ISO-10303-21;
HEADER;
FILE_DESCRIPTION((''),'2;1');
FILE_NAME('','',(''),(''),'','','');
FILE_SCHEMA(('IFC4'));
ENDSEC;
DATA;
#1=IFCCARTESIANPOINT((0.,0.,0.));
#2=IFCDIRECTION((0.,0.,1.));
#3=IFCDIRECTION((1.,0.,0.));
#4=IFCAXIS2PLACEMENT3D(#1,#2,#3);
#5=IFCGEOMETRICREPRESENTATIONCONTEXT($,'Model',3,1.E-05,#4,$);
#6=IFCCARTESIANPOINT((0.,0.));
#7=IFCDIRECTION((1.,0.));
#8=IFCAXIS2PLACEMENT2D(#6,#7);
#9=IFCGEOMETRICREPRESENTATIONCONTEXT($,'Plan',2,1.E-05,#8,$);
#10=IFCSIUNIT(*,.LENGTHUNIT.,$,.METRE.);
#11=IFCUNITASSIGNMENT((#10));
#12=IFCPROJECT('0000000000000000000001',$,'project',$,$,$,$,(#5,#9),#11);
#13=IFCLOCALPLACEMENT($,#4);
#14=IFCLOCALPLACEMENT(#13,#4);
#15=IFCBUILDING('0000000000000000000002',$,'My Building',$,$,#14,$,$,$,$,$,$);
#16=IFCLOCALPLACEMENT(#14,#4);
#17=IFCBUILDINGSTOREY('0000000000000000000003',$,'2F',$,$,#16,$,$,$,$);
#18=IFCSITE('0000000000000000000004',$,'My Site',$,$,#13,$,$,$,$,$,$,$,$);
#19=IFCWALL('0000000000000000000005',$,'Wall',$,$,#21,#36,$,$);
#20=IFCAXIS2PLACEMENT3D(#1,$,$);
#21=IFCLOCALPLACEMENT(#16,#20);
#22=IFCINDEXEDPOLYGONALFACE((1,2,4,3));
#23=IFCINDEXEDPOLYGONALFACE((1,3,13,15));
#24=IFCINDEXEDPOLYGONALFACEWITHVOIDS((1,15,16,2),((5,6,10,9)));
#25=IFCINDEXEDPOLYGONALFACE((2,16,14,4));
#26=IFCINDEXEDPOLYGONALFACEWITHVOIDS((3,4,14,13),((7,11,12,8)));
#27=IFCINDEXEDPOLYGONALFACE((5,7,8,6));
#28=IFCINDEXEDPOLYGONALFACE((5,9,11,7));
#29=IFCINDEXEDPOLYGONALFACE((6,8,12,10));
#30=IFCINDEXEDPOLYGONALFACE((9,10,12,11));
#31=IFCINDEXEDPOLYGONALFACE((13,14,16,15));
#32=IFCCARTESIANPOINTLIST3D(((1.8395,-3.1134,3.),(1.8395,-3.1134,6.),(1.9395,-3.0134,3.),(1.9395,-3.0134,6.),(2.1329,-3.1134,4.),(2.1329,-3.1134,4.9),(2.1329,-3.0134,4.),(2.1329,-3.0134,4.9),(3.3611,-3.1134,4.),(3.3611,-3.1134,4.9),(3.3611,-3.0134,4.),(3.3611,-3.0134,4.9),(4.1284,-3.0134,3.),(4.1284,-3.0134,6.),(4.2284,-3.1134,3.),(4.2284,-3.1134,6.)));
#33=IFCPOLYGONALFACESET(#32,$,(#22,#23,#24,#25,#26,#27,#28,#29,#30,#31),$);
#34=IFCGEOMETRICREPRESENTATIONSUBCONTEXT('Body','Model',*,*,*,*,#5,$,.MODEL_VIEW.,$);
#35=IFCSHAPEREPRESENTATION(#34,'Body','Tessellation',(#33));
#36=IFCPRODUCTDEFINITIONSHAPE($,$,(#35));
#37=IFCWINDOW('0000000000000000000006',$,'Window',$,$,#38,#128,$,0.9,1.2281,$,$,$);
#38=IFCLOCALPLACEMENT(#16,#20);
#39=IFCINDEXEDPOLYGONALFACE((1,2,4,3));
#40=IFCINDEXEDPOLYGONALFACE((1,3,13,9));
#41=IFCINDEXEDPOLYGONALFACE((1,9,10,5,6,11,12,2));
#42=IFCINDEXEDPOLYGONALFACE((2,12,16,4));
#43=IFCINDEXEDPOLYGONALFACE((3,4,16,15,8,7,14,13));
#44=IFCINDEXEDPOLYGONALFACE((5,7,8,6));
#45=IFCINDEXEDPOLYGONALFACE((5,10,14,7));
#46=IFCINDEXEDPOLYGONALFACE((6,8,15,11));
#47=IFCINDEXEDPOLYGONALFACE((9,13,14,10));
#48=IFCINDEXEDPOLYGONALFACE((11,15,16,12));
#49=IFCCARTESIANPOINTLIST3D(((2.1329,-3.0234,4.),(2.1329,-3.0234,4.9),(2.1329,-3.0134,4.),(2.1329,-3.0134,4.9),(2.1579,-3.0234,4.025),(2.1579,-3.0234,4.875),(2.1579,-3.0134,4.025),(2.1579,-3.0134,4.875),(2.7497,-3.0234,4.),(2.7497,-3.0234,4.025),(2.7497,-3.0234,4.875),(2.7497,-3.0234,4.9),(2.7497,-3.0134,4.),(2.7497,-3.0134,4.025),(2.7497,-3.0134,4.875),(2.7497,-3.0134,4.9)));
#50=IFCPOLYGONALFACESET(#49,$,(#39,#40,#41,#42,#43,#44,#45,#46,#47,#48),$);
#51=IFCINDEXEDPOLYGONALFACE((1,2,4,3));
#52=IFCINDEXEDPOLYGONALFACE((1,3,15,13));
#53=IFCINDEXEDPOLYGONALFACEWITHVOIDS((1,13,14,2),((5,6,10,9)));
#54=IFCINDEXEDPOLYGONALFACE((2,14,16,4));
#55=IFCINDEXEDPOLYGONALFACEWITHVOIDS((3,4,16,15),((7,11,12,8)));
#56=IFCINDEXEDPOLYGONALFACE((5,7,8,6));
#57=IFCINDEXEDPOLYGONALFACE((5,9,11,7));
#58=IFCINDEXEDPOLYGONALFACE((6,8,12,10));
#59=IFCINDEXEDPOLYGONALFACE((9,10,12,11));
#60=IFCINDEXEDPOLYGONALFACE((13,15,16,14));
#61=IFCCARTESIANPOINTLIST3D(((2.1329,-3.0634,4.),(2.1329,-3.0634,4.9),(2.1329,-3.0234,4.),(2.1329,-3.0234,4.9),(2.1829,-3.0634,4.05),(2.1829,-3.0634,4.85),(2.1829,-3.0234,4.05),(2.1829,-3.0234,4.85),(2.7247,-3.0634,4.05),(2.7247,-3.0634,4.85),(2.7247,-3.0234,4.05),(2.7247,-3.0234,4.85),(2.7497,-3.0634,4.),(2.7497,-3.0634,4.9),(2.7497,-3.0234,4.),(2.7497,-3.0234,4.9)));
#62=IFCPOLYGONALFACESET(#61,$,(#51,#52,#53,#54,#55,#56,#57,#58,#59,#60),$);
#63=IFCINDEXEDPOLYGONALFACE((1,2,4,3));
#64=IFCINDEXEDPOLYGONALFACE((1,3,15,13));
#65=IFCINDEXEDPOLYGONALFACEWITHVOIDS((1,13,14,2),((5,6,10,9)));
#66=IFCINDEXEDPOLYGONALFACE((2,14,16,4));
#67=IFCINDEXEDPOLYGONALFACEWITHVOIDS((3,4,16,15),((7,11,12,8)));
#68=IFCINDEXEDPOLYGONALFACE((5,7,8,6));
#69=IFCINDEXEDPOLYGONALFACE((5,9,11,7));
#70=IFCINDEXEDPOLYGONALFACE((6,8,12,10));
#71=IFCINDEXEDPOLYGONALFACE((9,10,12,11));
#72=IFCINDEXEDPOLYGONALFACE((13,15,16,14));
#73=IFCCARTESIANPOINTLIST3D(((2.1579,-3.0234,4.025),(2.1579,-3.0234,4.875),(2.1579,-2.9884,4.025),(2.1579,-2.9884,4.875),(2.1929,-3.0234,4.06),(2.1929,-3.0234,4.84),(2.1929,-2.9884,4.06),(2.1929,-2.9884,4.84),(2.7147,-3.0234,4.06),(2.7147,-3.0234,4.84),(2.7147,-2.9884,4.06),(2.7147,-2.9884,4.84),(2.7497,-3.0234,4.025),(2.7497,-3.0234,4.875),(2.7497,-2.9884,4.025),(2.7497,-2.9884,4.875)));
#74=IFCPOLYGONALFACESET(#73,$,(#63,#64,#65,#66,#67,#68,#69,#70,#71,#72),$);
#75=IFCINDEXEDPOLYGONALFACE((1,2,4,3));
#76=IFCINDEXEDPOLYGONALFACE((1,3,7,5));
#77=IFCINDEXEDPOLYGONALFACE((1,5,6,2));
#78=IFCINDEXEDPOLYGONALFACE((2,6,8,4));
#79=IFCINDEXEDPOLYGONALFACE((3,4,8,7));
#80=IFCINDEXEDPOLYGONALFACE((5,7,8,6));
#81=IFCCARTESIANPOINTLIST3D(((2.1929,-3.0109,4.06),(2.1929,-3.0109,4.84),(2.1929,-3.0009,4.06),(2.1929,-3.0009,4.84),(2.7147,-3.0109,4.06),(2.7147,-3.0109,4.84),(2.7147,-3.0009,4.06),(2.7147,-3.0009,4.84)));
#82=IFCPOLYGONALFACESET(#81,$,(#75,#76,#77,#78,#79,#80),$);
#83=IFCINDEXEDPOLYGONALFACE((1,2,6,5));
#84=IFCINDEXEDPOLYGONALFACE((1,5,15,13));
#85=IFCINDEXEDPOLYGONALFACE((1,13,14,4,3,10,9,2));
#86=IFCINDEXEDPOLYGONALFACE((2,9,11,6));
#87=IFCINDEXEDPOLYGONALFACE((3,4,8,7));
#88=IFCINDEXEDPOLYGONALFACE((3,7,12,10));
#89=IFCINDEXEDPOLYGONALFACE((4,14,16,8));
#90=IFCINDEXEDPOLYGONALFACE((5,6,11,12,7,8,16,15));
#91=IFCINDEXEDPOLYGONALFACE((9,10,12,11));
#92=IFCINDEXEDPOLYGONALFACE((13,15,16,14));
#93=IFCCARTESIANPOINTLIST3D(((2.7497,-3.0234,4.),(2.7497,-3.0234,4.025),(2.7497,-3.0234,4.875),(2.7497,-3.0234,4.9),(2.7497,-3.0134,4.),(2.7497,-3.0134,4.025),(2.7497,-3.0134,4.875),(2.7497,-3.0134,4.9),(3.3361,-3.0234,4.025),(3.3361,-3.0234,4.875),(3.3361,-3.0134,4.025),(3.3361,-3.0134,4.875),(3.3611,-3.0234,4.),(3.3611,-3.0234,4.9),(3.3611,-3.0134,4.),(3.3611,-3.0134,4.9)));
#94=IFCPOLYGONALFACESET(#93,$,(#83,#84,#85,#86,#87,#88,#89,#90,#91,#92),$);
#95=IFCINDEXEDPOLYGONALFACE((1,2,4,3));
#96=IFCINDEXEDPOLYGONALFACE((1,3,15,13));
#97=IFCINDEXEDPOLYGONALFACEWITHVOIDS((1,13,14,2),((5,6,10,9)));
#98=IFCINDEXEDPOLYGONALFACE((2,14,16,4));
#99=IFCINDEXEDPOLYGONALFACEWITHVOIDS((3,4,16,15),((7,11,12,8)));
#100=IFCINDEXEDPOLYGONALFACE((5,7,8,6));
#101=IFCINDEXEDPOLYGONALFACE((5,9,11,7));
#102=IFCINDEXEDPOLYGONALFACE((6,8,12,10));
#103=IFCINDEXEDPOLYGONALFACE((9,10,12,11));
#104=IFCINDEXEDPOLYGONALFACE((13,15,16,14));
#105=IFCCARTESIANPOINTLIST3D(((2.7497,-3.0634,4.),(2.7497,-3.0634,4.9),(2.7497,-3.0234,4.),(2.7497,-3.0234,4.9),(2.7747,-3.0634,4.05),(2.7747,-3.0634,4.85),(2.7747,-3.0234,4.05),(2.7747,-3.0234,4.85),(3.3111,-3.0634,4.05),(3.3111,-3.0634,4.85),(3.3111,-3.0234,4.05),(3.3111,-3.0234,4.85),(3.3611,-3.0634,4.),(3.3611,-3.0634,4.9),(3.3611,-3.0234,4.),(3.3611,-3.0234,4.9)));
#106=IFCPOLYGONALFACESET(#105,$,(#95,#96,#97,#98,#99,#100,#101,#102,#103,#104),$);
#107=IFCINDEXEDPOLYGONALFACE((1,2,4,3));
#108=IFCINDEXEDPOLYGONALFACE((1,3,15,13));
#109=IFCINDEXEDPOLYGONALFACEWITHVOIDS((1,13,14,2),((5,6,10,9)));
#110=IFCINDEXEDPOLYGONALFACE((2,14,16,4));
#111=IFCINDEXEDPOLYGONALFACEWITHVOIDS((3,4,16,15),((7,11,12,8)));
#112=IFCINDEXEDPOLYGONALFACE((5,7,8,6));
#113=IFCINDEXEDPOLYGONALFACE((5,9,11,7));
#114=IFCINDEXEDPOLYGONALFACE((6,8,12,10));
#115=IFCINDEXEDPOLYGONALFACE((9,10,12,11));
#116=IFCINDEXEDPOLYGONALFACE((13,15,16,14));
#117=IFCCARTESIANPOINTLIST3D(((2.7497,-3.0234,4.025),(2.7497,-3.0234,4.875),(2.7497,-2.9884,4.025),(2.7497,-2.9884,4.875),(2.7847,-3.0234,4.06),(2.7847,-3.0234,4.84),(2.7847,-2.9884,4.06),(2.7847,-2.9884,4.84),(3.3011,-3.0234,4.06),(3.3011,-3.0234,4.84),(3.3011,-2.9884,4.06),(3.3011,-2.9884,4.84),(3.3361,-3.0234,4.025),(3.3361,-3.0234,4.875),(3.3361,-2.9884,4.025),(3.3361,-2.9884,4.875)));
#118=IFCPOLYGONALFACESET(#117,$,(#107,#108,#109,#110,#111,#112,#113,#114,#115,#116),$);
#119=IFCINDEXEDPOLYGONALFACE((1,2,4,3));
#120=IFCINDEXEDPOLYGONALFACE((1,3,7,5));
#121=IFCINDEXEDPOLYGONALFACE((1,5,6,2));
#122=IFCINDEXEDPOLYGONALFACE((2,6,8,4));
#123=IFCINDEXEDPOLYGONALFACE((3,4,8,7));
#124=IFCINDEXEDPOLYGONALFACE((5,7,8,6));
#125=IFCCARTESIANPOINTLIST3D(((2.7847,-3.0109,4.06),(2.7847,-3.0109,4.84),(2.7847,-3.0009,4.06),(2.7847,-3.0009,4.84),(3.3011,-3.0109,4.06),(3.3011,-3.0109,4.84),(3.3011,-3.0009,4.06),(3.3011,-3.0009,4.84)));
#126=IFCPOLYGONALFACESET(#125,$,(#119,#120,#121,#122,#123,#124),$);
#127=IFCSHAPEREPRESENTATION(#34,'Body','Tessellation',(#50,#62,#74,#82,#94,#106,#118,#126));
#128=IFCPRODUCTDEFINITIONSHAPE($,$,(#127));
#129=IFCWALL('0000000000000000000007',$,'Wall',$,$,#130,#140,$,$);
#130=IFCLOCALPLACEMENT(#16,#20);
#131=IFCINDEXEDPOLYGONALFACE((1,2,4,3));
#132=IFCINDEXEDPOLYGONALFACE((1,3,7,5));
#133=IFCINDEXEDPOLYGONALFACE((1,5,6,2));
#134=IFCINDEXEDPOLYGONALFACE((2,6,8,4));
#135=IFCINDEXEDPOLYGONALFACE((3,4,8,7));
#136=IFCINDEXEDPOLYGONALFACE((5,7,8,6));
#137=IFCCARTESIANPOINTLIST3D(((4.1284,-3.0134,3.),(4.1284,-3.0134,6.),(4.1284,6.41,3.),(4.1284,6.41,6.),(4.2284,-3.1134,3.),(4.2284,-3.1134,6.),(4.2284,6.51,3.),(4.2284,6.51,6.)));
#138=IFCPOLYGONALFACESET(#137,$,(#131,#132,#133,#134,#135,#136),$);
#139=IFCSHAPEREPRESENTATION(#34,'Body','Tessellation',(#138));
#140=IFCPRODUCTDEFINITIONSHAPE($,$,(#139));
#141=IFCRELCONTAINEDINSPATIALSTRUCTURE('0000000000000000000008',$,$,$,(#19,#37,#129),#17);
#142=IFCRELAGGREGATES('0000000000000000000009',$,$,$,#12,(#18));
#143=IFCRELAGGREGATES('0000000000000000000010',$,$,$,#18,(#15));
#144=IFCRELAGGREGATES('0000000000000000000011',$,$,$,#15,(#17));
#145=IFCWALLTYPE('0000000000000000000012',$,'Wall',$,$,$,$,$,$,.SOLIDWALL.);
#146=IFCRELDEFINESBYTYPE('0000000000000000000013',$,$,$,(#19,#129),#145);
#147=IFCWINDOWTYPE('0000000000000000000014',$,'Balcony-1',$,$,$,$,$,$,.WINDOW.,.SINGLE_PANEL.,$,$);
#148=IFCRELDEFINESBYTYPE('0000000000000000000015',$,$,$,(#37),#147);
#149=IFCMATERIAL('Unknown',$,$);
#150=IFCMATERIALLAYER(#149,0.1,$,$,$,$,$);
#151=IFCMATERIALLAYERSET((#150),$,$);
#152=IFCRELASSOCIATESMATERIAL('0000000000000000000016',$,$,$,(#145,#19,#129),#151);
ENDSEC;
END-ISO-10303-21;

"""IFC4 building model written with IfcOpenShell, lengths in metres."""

from ifc_helpers import new_model, entity, si_unit, frame, origin_with_axes, origin_2d_with_axis, place, context, subcontext, project, spatial, line, indexed_curve, outline, extrude, shape, source, transform, mapped, material, layer, layer_set, layer_usage, type_object, type_shapes, element, fill, save


model = new_model("IFC4")

# Units and contexts
model_context = context("Model", 3, precision=1e-05, world=origin_with_axes())
plan_context = context("Plan", 2, precision=1e-05, world=origin_2d_with_axis())
body_context_1 = subcontext(model_context, "Body", "Model", "MODEL_VIEW")
body_context_2 = subcontext(plan_context, "Body", "Plan", "PLAN_VIEW")
ifc_project = project(units=[si_unit("LENGTHUNIT", "METRE")], contexts=[model_context, plan_context])

# Site, building, storey
site_placement = place(None, origin_with_axes())
site = spatial("IfcSite", under=ifc_project, at=site_placement, Name="My Site")
building_placement = place(site_placement, origin_with_axes())
building = spatial("IfcBuilding", under=site, at=building_placement, Name="My Building")
storey_placement = place(building_placement, origin_with_axes())
storey = spatial("IfcBuildingStorey", under=building, at=storey_placement, Name="2F")

# Shared definitions
ifc_material = material(Name="Unknown")
ifc_layer = layer(ifc_material, 0.1)
ifc_layer_set = layer_set([ifc_layer])
wall_type = type_object("IfcWallType", Name="Wall", PredefinedType="SOLIDWALL", material=ifc_layer_set)

# Wall, opening, window
ifc_layer_usage_1 = layer_usage(ifc_layer_set, "AXIS2", "POSITIVE", 0.0)
wall_1_placement = place(storey_placement, frame((1.8395, -3.1134, 3.0), z_axis=(0.0, 0.0, 1.0), x_axis=(1.0, 0.0, 0.0)))
wall_1 = element("IfcWall", 1, at=wall_1_placement, inside=storey, type_object=wall_type, material=ifc_layer_usage_1, Name="Wall", context=body_context_1, shape_type="SweptSolid", body=[
    extrude(outline(indexed_curve([(0.0, 0.0), (0.1, 0.1), (2.2889, 0.1), (2.3889, 0.0)], segments=[line(1, 2, 3, 4, 1)])), origin_with_axes(), (0.0, 0.0, 1.0), 3.0),
])
shared_shape_1 = source(origin_with_axes(), body_context_1, "Body", "SweptSolid", [
    extrude(outline(indexed_curve([(0.0, 0.0), (1.2281, 0.0), (1.2281, 0.9), (0.0, 0.9)], segments=[line(1, 2, 3, 4, 1)])), frame((0.0, -0.6, 0.0), z_axis=(0.0, -1.0, 0.0), x_axis=(1.0, 0.0, 0.0)), (0.0, 0.0, -1.0), 1.2),
])
opening_1_placement = place(wall_1_placement, frame((0.2934, 0.0, 1.0), z_axis=(0.0, 0.0, 1.0), x_axis=(1.0, 0.0, 0.0)))
opening_1 = element("IfcOpeningElement", 2, at=opening_1_placement, cuts=wall_1, PredefinedType="OPENING", context=body_context_1, shape_type="MappedRepresentation", body=[
    mapped(shared_shape_1, transform((0.0, 0.0, 0.0), x_axis=(1.0, 0.0, 0.0), y_axis=(0.0, 1.0, 0.0), z_axis=(0.0, 0.0, 1.0), scale=1.0)),
])
window_type_1 = type_object("IfcWindowType", Name="Balcony-1", PartitioningType="SINGLE_PANEL", PredefinedType="WINDOW")
shared_shape_2 = source(origin_with_axes(), body_context_1, "Body", "SweptSolid", [
    extrude(outline(indexed_curve([(0.6167, 0.0), (0.0, 0.0), (0.0, 0.9), (0.6167, 0.9), (0.6167, 0.875), (0.025, 0.875), (0.025, 0.025), (0.6167, 0.025)], segments=[line(1, 2, 3, 4, 5, 6, 7, 8, 1)])), frame((0.0, 0.09, 0.0), z_axis=(0.0, -1.0, 0.0), x_axis=(1.0, 0.0, 0.0)), (0.0, 0.0, -1.0), 0.01),
    extrude(outline(indexed_curve([(0.0, 0.0), (0.6167, 0.0), (0.6167, 0.9), (0.0, 0.9)], segments=[line(1, 2, 3, 4, 1)]), holes=[indexed_curve([(0.05, 0.05), (0.5917, 0.05), (0.5917, 0.85), (0.05, 0.85)], segments=[line(1, 2, 3, 4, 1)])]), frame((0.0, 0.05, 0.0), z_axis=(0.0, -1.0, 0.0), x_axis=(1.0, 0.0, 0.0)), (0.0, 0.0, -1.0), 0.04),
    extrude(outline(indexed_curve([(0.0, 0.0), (0.5917, 0.0), (0.5917, 0.85), (0.0, 0.85)], segments=[line(1, 2, 3, 4, 1)]), holes=[indexed_curve([(0.035, 0.035), (0.5567, 0.035), (0.5567, 0.815), (0.035, 0.815)], segments=[line(1, 2, 3, 4, 1)])]), frame((0.025, 0.09, 0.025), z_axis=(0.0, -1.0, 0.0), x_axis=(1.0, 0.0, 0.0)), (0.0, 0.0, -1.0), 0.035),
    extrude(outline(indexed_curve([(0.035, 0.035), (0.5567, 0.035), (0.5567, 0.815), (0.035, 0.815)], segments=[line(1, 2, 3, 4, 1)])), frame((0.025, 0.1025, 0.025), z_axis=(0.0, -1.0, 0.0), x_axis=(1.0, 0.0, 0.0)), (0.0, 0.0, -1.0), 0.01),
    extrude(outline(indexed_curve([(0.0, 0.9), (0.6114, 0.9), (0.6114, 0.0), (0.0, 0.0), (0.0, 0.025), (0.5864, 0.025), (0.5864, 0.875), (0.0, 0.875)], segments=[line(1, 2, 3, 4, 5, 6, 7, 8, 1)])), frame((0.6167, 0.09, 0.0), z_axis=(0.0, -1.0, 0.0), x_axis=(1.0, 0.0, 0.0)), (0.0, 0.0, -1.0), 0.01),
    extrude(outline(indexed_curve([(0.0, 0.0), (0.6114, 0.0), (0.6114, 0.9), (0.0, 0.9)], segments=[line(1, 2, 3, 4, 1)]), holes=[indexed_curve([(0.025, 0.05), (0.5614, 0.05), (0.5614, 0.85), (0.025, 0.85)], segments=[line(1, 2, 3, 4, 1)])]), frame((0.6167, 0.05, 0.0), z_axis=(0.0, -1.0, 0.0), x_axis=(1.0, 0.0, 0.0)), (0.0, 0.0, -1.0), 0.04),
    extrude(outline(indexed_curve([(0.0, 0.0), (0.5864, 0.0), (0.5864, 0.85), (0.0, 0.85)], segments=[line(1, 2, 3, 4, 1)]), holes=[indexed_curve([(0.035, 0.035), (0.5514, 0.035), (0.5514, 0.815), (0.035, 0.815)], segments=[line(1, 2, 3, 4, 1)])]), frame((0.6167, 0.09, 0.025), z_axis=(0.0, -1.0, 0.0), x_axis=(1.0, 0.0, 0.0)), (0.0, 0.0, -1.0), 0.035),
    extrude(outline(indexed_curve([(0.035, 0.035), (0.5514, 0.035), (0.5514, 0.815), (0.035, 0.815)], segments=[line(1, 2, 3, 4, 1)])), frame((0.6167, 0.1025, 0.025), z_axis=(0.0, -1.0, 0.0), x_axis=(1.0, 0.0, 0.0)), (0.0, 0.0, -1.0), 0.01),
])
shared_shape_3 = source(origin_with_axes(), body_context_2, "Body", "Curve2D", [
    entity("IfcIndexedPolyCurve", entity("IfcCartesianPointList2D", [[0.05, 0.05], [0.5917, 0.05]])),
    entity("IfcIndexedPolyCurve", entity("IfcCartesianPointList2D", [[0.0, 0.1], [0.025, 0.1], [0.025, 0.09], [0.05, 0.09], [0.05, 0.05], [0.0, 0.05]]), [entity("IfcLineIndex", [1, 2, 3, 4, 5, 6, 1])]),
    entity("IfcIndexedPolyCurve", entity("IfcCartesianPointList2D", [[0.6167, 0.1], [0.6167, 0.1], [0.6167, 0.09], [0.5917, 0.09], [0.5917, 0.05], [0.6167, 0.05]])),
    entity("IfcIndexedPolyCurve", entity("IfcCartesianPointList2D", [[0.025, 0.09], [0.06, 0.09], [0.06, 0.125], [0.025, 0.125]]), [entity("IfcLineIndex", [1, 2, 3, 4, 1])]),
    entity("IfcIndexedPolyCurve", entity("IfcCartesianPointList2D", [[0.6167, 0.09], [0.5817, 0.09], [0.5817, 0.125], [0.6167, 0.125]]), [entity("IfcLineIndex", [1, 2, 3, 4, 1])]),
    entity("IfcIndexedPolyCurve", entity("IfcCartesianPointList2D", [[0.06, 0.09], [0.5817, 0.09]])),
    entity("IfcIndexedPolyCurve", entity("IfcCartesianPointList2D", [[0.06, 0.125], [0.5817, 0.125]])),
    entity("IfcIndexedPolyCurve", entity("IfcCartesianPointList2D", [[0.06, 0.1075], [0.5817, 0.1075]])),
    entity("IfcIndexedPolyCurve", entity("IfcCartesianPointList2D", [[0.6417, 0.05], [1.1781, 0.05]])),
    entity("IfcIndexedPolyCurve", entity("IfcCartesianPointList2D", [[0.6167, 0.1], [0.6167, 0.1], [0.6167, 0.09], [0.6417, 0.09], [0.6417, 0.05], [0.6167, 0.05]])),
    entity("IfcIndexedPolyCurve", entity("IfcCartesianPointList2D", [[1.2281, 0.1], [1.2031, 0.1], [1.2031, 0.09], [1.1781, 0.09], [1.1781, 0.05], [1.2281, 0.05]]), [entity("IfcLineIndex", [1, 2, 3, 4, 5, 6, 1])]),
    entity("IfcIndexedPolyCurve", entity("IfcCartesianPointList2D", [[0.6167, 0.09], [0.6517, 0.09], [0.6517, 0.125], [0.6167, 0.125]]), [entity("IfcLineIndex", [1, 2, 3, 4, 1])]),
    entity("IfcIndexedPolyCurve", entity("IfcCartesianPointList2D", [[1.2031, 0.09], [1.1681, 0.09], [1.1681, 0.125], [1.2031, 0.125]]), [entity("IfcLineIndex", [1, 2, 3, 4, 1])]),
    entity("IfcIndexedPolyCurve", entity("IfcCartesianPointList2D", [[0.6517, 0.09], [1.1681, 0.09]])),
    entity("IfcIndexedPolyCurve", entity("IfcCartesianPointList2D", [[0.6517, 0.125], [1.1681, 0.125]])),
    entity("IfcIndexedPolyCurve", entity("IfcCartesianPointList2D", [[0.6517, 0.1075], [1.1681, 0.1075]])),
])
type_shapes(window_type_1, [shared_shape_2, shared_shape_3])
window_1_placement = place(opening_1_placement, frame((0.0, 0.0, 0.0), z_axis=(0.0, 0.0, 1.0), x_axis=(1.0, 0.0, 0.0)))
window_1 = element("IfcWindow", 3, at=window_1_placement, inside=storey, type_object=window_type_1, Name="Window", OverallHeight=0.9, OverallWidth=1.2281, shapes=[
    shape(body_context_1, "Body", "MappedRepresentation", [mapped(shared_shape_2, transform((0.0, 0.0, 0.0), x_axis=(1.0, 0.0, 0.0), y_axis=(0.0, 1.0, 0.0), z_axis=(0.0, 0.0, 1.0), scale=1.0))]),
    shape(body_context_2, "Body", "MappedRepresentation", [mapped(shared_shape_3, transform((0.0, 0.0, 0.0), x_axis=(1.0, 0.0, 0.0), y_axis=(0.0, 1.0, 0.0), z_axis=(0.0, 0.0, 1.0), scale=1.0))]),
])
fill(opening_1, window_1)

# Wall
ifc_layer_usage_2 = layer_usage(ifc_layer_set, "AXIS2", "POSITIVE", 0.0)
wall_2_placement = place(storey_placement, frame((4.2284, -3.1134, 3.0), z_axis=(0.0, 0.0, 1.0), x_axis=(0.0, 1.0, 0.0)))
element("IfcWall", 4, at=wall_2_placement, inside=storey, type_object=wall_type, material=ifc_layer_usage_2, Name="Wall", context=body_context_1, shape_type="SweptSolid", body=[
    extrude(outline(indexed_curve([(0.0, 0.0), (0.1, 0.1), (9.5233, 0.1), (9.6233, 0.0)], segments=[line(1, 2, 3, 4, 1)])), origin_with_axes(), (0.0, 0.0, 1.0), 3.0),
])

save(model, "model.ifc")
